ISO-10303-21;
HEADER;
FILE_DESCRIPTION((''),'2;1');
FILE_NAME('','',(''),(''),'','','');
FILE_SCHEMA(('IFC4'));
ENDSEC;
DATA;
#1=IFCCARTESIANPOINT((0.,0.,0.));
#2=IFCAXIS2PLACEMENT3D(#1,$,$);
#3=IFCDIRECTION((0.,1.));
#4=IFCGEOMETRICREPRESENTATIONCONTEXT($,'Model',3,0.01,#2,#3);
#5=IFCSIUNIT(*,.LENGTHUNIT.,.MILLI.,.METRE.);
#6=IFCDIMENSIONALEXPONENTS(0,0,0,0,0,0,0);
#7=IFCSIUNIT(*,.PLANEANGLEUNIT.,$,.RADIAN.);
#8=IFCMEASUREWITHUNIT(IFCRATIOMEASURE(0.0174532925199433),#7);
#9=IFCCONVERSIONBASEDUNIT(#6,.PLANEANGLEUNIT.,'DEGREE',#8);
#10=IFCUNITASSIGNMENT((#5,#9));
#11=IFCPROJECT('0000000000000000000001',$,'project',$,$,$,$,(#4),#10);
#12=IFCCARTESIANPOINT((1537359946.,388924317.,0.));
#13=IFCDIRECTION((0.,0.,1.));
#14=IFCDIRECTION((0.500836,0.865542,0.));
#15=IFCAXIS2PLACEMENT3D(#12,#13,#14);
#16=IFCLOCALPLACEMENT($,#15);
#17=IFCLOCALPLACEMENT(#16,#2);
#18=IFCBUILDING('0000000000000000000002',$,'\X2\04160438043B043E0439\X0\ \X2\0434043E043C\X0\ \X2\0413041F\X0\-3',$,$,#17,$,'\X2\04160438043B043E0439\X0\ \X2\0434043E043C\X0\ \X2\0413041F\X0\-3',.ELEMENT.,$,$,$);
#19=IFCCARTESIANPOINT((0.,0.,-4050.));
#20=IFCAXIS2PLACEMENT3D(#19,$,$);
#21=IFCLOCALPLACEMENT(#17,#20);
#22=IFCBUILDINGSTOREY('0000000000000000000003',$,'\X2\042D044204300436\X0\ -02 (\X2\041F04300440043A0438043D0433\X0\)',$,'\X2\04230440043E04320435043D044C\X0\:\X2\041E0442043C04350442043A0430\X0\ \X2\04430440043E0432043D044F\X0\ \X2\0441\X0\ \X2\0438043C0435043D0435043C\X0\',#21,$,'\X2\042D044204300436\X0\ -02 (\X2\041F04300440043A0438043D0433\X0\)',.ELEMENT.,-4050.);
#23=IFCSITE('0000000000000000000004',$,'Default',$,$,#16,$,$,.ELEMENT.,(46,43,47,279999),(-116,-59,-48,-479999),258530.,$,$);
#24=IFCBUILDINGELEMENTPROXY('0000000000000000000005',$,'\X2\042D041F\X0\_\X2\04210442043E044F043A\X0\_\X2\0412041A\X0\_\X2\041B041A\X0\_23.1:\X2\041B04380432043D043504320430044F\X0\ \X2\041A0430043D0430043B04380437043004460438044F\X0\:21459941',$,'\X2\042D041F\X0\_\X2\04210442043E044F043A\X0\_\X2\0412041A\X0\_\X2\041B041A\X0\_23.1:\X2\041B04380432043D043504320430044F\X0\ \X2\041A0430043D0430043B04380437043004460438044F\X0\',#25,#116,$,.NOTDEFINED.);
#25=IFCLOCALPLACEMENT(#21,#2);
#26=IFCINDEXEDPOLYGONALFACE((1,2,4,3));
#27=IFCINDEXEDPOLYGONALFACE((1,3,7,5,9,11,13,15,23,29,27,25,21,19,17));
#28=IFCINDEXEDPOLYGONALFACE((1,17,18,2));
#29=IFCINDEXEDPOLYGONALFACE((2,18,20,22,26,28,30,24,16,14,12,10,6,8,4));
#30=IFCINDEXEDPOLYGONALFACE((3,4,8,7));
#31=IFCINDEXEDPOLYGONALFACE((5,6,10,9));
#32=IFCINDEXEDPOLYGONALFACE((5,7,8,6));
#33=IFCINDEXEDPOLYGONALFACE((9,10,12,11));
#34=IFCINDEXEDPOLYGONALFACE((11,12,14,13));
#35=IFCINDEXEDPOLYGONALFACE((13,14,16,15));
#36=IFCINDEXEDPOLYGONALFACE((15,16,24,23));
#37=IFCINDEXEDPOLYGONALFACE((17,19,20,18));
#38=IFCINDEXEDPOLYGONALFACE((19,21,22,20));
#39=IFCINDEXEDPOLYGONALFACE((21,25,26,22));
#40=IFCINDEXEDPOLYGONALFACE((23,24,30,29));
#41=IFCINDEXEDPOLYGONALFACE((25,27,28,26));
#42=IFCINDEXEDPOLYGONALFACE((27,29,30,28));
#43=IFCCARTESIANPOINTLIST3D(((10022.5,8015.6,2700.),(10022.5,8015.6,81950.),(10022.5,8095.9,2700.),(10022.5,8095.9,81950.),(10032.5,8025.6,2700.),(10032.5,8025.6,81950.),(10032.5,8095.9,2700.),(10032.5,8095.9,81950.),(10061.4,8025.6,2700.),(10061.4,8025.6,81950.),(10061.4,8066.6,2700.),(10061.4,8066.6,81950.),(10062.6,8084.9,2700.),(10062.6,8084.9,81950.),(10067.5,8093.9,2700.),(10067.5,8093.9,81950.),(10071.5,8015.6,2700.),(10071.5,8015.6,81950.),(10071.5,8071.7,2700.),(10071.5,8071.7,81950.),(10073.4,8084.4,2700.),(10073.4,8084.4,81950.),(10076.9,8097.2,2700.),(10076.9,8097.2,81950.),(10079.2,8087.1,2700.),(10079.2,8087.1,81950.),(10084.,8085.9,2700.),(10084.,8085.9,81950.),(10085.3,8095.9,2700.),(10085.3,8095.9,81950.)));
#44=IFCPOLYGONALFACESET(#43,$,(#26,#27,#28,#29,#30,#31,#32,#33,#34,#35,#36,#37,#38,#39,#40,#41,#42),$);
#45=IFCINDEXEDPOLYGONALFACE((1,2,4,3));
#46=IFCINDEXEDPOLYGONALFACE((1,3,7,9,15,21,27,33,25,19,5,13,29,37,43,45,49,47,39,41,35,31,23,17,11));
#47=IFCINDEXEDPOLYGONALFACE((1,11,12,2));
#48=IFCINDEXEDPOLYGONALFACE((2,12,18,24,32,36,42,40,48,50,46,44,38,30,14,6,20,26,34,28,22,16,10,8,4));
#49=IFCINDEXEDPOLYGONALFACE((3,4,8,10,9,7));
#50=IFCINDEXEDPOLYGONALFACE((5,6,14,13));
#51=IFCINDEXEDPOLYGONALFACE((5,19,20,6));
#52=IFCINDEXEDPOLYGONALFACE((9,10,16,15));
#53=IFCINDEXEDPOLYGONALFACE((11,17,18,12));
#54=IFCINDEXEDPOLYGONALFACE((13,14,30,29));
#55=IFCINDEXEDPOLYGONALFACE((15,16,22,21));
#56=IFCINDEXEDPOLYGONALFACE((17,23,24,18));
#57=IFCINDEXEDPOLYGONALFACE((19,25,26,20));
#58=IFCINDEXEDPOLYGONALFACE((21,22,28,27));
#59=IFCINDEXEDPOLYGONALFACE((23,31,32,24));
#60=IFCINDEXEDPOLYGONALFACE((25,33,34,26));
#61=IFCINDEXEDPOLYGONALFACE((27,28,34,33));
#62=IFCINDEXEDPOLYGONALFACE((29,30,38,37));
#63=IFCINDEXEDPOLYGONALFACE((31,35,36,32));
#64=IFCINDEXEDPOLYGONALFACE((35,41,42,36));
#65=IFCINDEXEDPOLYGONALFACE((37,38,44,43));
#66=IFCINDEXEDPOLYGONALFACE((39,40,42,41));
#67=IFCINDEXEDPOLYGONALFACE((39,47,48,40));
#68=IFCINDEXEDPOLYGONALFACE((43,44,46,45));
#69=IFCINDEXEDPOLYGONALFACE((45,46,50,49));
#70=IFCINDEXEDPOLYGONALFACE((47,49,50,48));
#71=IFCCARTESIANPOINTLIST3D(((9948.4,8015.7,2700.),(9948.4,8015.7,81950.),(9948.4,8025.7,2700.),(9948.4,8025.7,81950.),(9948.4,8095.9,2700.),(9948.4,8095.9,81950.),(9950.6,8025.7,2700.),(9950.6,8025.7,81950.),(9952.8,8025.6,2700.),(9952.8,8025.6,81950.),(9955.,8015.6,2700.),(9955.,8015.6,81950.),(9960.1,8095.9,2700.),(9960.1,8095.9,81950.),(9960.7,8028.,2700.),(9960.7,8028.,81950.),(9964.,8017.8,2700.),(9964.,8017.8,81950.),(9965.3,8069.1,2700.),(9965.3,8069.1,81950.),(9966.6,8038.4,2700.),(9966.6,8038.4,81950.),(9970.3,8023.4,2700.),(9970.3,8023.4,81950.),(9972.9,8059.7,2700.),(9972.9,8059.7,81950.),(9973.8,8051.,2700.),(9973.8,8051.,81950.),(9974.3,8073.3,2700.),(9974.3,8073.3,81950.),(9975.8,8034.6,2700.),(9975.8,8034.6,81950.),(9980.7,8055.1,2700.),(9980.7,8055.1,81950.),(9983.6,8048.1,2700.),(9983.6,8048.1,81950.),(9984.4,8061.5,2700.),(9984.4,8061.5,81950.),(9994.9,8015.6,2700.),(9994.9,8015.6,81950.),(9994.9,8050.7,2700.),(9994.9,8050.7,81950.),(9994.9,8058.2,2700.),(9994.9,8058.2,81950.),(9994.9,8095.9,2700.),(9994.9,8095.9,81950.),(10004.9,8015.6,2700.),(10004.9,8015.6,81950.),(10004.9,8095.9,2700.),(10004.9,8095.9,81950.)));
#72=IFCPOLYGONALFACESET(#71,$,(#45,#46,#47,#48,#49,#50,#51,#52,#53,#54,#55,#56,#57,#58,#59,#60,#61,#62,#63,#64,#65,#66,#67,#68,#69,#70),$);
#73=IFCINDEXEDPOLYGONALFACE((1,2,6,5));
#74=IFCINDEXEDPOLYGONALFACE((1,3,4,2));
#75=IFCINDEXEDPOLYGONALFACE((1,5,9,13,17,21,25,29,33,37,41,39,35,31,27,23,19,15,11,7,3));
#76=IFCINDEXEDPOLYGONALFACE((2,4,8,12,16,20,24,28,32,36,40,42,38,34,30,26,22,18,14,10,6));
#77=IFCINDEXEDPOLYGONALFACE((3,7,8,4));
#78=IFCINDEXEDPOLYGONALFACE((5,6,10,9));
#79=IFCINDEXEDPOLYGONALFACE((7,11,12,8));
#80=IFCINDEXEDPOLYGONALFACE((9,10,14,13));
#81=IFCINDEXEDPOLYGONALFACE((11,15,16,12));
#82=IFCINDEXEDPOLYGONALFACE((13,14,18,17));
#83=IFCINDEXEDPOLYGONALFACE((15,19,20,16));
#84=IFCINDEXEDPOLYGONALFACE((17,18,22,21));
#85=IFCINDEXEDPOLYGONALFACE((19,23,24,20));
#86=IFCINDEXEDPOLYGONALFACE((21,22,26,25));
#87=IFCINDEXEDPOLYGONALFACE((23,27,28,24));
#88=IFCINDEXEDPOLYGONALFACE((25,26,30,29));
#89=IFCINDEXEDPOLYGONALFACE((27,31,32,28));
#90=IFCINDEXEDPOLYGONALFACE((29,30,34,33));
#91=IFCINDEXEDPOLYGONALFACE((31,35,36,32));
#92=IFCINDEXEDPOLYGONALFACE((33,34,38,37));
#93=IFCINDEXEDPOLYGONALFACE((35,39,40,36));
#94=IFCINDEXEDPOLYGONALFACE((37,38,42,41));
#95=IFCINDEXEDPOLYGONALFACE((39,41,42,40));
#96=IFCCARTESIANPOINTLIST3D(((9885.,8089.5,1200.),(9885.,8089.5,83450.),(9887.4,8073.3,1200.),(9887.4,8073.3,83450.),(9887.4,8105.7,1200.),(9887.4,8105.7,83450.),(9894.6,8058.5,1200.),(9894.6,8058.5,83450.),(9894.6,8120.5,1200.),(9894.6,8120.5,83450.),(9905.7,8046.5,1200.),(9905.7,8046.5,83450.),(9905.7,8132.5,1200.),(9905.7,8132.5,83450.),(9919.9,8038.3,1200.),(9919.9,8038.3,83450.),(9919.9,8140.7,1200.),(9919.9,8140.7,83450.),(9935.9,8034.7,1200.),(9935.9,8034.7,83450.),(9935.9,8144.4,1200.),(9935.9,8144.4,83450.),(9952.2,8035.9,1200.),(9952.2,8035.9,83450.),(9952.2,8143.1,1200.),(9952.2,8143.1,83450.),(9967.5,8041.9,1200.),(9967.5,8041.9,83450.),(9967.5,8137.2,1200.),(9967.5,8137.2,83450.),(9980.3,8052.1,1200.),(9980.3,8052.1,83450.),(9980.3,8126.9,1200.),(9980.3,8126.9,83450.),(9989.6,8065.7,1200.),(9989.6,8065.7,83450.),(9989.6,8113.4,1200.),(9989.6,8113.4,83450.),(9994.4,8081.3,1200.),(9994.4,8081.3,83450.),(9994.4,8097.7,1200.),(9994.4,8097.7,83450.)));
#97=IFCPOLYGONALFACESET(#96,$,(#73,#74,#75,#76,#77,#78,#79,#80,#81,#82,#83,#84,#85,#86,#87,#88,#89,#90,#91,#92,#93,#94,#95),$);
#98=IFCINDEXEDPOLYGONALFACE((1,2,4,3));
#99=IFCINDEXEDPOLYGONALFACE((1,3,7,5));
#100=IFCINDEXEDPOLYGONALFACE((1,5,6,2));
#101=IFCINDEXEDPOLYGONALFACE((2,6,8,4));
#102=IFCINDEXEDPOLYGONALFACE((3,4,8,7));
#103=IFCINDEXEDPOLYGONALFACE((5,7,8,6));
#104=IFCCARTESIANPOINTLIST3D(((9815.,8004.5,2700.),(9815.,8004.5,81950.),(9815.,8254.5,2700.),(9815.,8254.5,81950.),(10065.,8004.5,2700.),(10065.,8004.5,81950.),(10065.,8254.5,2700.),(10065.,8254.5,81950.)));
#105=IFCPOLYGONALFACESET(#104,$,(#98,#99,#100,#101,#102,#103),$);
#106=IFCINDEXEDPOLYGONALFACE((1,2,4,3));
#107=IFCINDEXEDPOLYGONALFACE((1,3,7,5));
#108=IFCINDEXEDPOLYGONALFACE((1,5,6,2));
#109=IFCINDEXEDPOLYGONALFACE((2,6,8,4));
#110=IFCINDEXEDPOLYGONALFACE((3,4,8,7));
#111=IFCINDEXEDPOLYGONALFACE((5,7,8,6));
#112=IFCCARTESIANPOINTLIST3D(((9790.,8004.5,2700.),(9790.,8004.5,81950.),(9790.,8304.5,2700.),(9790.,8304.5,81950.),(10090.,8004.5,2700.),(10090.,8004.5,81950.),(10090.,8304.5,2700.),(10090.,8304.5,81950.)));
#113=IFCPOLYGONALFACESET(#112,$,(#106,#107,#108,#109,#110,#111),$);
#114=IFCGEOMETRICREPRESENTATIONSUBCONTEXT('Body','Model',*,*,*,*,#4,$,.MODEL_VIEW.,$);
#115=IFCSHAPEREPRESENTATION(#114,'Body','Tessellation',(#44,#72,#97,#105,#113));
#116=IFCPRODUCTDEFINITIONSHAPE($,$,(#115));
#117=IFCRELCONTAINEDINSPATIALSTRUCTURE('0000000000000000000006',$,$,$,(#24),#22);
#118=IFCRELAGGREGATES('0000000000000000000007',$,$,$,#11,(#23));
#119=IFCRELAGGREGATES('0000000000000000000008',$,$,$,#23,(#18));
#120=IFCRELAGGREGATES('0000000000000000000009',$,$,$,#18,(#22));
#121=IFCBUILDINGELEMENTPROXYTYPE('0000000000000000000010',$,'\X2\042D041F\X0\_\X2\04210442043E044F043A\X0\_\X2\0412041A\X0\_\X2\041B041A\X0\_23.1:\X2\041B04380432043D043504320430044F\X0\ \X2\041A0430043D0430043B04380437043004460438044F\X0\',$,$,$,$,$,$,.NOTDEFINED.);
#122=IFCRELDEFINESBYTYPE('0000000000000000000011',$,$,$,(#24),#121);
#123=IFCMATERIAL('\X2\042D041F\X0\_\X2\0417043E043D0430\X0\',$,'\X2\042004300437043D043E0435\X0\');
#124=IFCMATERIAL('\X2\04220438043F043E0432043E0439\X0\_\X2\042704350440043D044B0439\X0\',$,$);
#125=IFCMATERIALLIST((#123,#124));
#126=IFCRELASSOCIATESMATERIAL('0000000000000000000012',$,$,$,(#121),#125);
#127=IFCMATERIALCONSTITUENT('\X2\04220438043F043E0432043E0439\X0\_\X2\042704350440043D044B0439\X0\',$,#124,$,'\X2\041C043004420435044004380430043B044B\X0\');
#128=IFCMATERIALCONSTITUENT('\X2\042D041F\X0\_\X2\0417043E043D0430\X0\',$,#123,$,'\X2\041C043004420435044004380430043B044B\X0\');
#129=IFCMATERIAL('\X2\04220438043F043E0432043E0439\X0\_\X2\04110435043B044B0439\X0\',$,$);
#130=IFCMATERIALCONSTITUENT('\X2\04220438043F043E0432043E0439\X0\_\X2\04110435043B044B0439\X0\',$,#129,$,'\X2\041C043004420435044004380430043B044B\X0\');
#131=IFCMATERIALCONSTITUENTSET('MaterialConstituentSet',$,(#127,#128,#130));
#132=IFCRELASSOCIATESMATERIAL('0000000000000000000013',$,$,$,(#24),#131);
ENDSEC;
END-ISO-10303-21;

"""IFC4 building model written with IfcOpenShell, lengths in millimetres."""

from ifc_helpers import new_model, entity, si_unit, converted_unit, direction, frame, frame_2d, origin, place, context, subcontext, project, spatial, polyline, rectangle, circle, outline, extrude, source, transform, mapped, material, material_list, constituent, constituent_set, type_object, type_shapes, element, save


model = new_model("IFC4")

# Units and contexts
model_context = context("Model", 3, precision=0.01, world=origin(), true_north=direction((0.0, 1.0)))
body_context = subcontext(model_context, "Body", "Model", "MODEL_VIEW")
ifc_project = project(units=[si_unit("LENGTHUNIT", "METRE", prefix="MILLI"), converted_unit("PLANEANGLEUNIT", "DEGREE", entity("IfcRatioMeasure", 0.0174532925199433), si_unit("PLANEANGLEUNIT", "RADIAN"), dimensions=[0, 0, 0, 0, 0, 0, 0])], contexts=[model_context])

# Site, building, storey
site_placement = place(None, frame((1537359946.0, 388924317.0, 0.0), z_axis=(0.0, 0.0, 1.0), x_axis=(0.500836, 0.865542, 0.0)))
site = spatial("IfcSite", under=ifc_project, at=site_placement, Name="Default", CompositionType="ELEMENT", RefLatitude=(46, 43, 47, 279999), RefLongitude=(-116, -59, -48, -479999), RefElevation=258530.0)
building_placement = place(site_placement, origin())
building = spatial("IfcBuilding", under=site, at=building_placement, Name="Жилой дом ГП-3", LongName="Жилой дом ГП-3", CompositionType="ELEMENT")
storey_placement = place(building_placement, frame((0.0, 0.0, -4050.0)))
storey = spatial("IfcBuildingStorey", under=building, at=storey_placement, Name="Этаж -02 (Паркинг)", ObjectType="Уровень:Отметка уровня с именем", LongName="Этаж -02 (Паркинг)", CompositionType="ELEMENT", Elevation=-4050.0)

# Building element proxy
ifc_material_1 = material(Name="Типовой_Черный")
ifc_material_2 = material(Name="ЭП_Зона", Category="Разное")
ifc_constituent_1 = constituent(ifc_material_1, Name="Типовой_Черный", Category="Материалы")
ifc_constituent_2 = constituent(ifc_material_2, Name="ЭП_Зона", Category="Материалы")
ifc_material_3 = material(Name="Типовой_Белый")
ifc_constituent_3 = constituent(ifc_material_3, Name="Типовой_Белый", Category="Материалы")
ifc_constituent_set_1 = constituent_set(constituents=[ifc_constituent_1, ifc_constituent_2, ifc_constituent_3], Name="MaterialConstituentSet")
ifc_material_list_1 = material_list([ifc_material_2, ifc_material_1])
building_element_proxy_type_1 = type_object("IfcBuildingElementProxyType", Name="ЭП_Стояк_ВК_ЛК_23.1:Ливневая Канализация", PredefinedType="NOTDEFINED", material=ifc_material_list_1)
shared_shape_1 = source(origin(), body_context, "Body", "SweptSolid", [
    extrude(outline(polyline([(-53.9, 11.1), (-53.9, -37.8), (26.5, -37.8), (26.5, -27.8), (-43.9, -27.8), (-43.9, 1.1), (-2.9, 1.1), (15.4, 2.3), (24.5, 7.2), (27.7, 16.6), (26.5, 25.0), (16.4, 23.7), (17.7, 18.9), (15.0, 13.1), (2.3, 11.1), (-53.9, 11.1)])), frame((29.7, -64.9, -1350.0), z_axis=(0.0, 0.0, -1.0), x_axis=(0.0, -1.0, 0.0)), (0.0, 0.0, -1.0), 79250.0),
    extrude(outline(polyline([(-32.1, -31.9), (48.3, -31.9), (48.3, -21.8), (10.6, -21.8), (13.8, -11.4), (25.6, -1.3), (48.3, 13.0), (48.3, 24.6), (21.4, 7.7), (12.0, 0.1), (7.4, -7.7), (3.3, -0.7), (-9.3, 6.4), (-19.7, 12.3), (-22.1, 20.2), (-22.0, 22.4), (-22.0, 24.6), (-32.0, 24.6), (-32.1, 18.0), (-29.9, 9.0), (-24.3, 2.8), (-13.1, -2.8), (0.4, -10.6), (3.0, -21.8), (-32.1, -21.8), (-32.1, -31.9)])), frame((117.0, -43.1, -1350.0), z_axis=(0.0, 0.0, 1.0), x_axis=(0.0, -1.0, 0.0)), (0.0, 0.0, 1.0), 79250.0),
    extrude(circle(Radius=55.0, at=frame_2d((0.0, 0.0), x_axis=(1.0, 0.0))), frame((150.0, -85.0, -2850.0)), (0.0, 0.0, 1.0), 82250.0),
    extrude(rectangle(XDim=250.0, YDim=250.0, at=frame_2d((0.0, 0.0), x_axis=(1.0, 0.0))), frame((150.0, -125.0, -1350.0)), (0.0, 0.0, 1.0), 79250.0),
    extrude(rectangle(XDim=300.0, YDim=300.0, at=frame_2d((0.0, 0.0), x_axis=(1.0, 0.0))), frame((150.0, -150.0, -1350.0)), (0.0, 0.0, 1.0), 79250.0),
])
type_shapes(building_element_proxy_type_1, [shared_shape_1])
proxy_1_placement = place(storey_placement, frame((10090.0, 8004.5, 4050.0), z_axis=(0.0, 0.0, 1.0), x_axis=(-1.0, 0.0, 0.0)))
element("IfcBuildingElementProxy", 1, at=proxy_1_placement, inside=storey, type_object=building_element_proxy_type_1, material=ifc_constituent_set_1, Name="ЭП_Стояк_ВК_ЛК_23.1:Ливневая Канализация:21459941", ObjectType="ЭП_Стояк_ВК_ЛК_23.1:Ливневая Канализация", PredefinedType="NOTDEFINED", context=body_context, shape_type="MappedRepresentation", body=[
    mapped(shared_shape_1, transform((0.0, 0.0, 0.0), scale=1.0)),
])

save(model, "model.ifc")
